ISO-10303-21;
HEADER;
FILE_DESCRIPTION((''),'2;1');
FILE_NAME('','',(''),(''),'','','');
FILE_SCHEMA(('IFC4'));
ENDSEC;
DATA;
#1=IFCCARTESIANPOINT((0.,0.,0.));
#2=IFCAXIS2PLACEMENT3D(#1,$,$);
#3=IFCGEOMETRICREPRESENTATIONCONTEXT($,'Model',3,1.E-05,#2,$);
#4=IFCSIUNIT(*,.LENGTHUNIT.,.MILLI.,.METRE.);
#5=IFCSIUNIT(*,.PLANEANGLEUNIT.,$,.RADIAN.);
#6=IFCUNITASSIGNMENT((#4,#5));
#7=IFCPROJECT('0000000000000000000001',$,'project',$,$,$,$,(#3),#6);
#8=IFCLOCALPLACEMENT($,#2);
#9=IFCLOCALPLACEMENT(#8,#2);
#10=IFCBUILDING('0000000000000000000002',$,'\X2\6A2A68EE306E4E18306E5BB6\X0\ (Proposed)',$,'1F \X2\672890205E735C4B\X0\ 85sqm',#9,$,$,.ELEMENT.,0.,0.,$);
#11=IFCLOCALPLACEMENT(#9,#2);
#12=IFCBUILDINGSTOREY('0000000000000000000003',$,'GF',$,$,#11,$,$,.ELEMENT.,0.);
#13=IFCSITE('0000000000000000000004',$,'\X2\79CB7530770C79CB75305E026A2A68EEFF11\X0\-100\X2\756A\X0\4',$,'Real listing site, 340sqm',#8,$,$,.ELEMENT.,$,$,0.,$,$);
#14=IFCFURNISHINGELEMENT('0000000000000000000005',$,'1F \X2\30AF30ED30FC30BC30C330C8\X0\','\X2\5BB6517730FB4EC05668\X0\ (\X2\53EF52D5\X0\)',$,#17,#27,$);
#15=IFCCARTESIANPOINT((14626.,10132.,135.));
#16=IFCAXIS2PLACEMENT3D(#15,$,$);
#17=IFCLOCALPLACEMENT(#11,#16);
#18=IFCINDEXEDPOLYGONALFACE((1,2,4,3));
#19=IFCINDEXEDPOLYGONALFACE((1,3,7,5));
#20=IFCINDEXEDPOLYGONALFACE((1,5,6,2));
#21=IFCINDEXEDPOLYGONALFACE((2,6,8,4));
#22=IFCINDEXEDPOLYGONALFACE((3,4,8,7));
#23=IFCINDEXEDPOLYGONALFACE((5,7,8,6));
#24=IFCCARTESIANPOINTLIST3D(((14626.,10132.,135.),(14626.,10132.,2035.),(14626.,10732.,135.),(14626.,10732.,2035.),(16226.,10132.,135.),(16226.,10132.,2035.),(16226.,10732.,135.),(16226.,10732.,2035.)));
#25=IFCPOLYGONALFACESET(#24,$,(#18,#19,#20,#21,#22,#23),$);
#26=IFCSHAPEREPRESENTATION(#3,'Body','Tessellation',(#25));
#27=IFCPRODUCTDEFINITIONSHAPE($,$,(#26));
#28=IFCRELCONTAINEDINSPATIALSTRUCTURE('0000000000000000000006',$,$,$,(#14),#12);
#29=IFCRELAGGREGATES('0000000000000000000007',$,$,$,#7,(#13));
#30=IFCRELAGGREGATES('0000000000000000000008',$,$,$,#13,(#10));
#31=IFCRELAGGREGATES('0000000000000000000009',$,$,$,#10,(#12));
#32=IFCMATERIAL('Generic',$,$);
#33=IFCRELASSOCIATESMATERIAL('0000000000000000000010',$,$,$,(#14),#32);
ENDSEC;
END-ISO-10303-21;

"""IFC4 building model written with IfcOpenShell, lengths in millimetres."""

from ifc_helpers import new_model, si_unit, frame, frame_2d, origin, place, context, project, spatial, rectangle, extrude, material, element, save


model = new_model("IFC4")

# Units and contexts
model_context = context("Model", 3, precision=1e-05, world=origin())
ifc_project = project(units=[si_unit("LENGTHUNIT", "METRE", prefix="MILLI"), si_unit("PLANEANGLEUNIT", "RADIAN")], contexts=[model_context])

# Site, building, storey
site_placement = place(None, origin())
site = spatial("IfcSite", under=ifc_project, at=site_placement, Name="秋田県秋田市横森１-100番4", ObjectType="Real listing site, 340sqm", CompositionType="ELEMENT", RefElevation=0.0)
building_placement = place(site_placement, origin())
building = spatial("IfcBuilding", under=site, at=building_placement, Name="横森の丘の家 (Proposed)", ObjectType="1F 木造平屋 85sqm", CompositionType="ELEMENT", ElevationOfRefHeight=0.0, ElevationOfTerrain=0.0)
storey_placement = place(building_placement, origin())
storey = spatial("IfcBuildingStorey", under=building, at=storey_placement, Name="GF", CompositionType="ELEMENT", Elevation=0.0)

# Shared definitions
ifc_material_1 = material(Name="Generic")

# Furnishing element
furnishing_placement = place(storey_placement, frame((14626.0, 10132.0, 135.0)))
element("IfcFurnishingElement", 1, at=furnishing_placement, inside=storey, material=ifc_material_1, Name="1F クローゼット", Description="家具・什器 (可動)", context=model_context, shape_type="SweptSolid", body=[
    extrude(rectangle(XDim=1600.0, YDim=600.0, at=frame_2d((800.0, 300.0))), frame((14626.0, 10132.0, 135.0)), (0.0, 0.0, 1.0), 1900.0),
])

save(model, "model.ifc")
